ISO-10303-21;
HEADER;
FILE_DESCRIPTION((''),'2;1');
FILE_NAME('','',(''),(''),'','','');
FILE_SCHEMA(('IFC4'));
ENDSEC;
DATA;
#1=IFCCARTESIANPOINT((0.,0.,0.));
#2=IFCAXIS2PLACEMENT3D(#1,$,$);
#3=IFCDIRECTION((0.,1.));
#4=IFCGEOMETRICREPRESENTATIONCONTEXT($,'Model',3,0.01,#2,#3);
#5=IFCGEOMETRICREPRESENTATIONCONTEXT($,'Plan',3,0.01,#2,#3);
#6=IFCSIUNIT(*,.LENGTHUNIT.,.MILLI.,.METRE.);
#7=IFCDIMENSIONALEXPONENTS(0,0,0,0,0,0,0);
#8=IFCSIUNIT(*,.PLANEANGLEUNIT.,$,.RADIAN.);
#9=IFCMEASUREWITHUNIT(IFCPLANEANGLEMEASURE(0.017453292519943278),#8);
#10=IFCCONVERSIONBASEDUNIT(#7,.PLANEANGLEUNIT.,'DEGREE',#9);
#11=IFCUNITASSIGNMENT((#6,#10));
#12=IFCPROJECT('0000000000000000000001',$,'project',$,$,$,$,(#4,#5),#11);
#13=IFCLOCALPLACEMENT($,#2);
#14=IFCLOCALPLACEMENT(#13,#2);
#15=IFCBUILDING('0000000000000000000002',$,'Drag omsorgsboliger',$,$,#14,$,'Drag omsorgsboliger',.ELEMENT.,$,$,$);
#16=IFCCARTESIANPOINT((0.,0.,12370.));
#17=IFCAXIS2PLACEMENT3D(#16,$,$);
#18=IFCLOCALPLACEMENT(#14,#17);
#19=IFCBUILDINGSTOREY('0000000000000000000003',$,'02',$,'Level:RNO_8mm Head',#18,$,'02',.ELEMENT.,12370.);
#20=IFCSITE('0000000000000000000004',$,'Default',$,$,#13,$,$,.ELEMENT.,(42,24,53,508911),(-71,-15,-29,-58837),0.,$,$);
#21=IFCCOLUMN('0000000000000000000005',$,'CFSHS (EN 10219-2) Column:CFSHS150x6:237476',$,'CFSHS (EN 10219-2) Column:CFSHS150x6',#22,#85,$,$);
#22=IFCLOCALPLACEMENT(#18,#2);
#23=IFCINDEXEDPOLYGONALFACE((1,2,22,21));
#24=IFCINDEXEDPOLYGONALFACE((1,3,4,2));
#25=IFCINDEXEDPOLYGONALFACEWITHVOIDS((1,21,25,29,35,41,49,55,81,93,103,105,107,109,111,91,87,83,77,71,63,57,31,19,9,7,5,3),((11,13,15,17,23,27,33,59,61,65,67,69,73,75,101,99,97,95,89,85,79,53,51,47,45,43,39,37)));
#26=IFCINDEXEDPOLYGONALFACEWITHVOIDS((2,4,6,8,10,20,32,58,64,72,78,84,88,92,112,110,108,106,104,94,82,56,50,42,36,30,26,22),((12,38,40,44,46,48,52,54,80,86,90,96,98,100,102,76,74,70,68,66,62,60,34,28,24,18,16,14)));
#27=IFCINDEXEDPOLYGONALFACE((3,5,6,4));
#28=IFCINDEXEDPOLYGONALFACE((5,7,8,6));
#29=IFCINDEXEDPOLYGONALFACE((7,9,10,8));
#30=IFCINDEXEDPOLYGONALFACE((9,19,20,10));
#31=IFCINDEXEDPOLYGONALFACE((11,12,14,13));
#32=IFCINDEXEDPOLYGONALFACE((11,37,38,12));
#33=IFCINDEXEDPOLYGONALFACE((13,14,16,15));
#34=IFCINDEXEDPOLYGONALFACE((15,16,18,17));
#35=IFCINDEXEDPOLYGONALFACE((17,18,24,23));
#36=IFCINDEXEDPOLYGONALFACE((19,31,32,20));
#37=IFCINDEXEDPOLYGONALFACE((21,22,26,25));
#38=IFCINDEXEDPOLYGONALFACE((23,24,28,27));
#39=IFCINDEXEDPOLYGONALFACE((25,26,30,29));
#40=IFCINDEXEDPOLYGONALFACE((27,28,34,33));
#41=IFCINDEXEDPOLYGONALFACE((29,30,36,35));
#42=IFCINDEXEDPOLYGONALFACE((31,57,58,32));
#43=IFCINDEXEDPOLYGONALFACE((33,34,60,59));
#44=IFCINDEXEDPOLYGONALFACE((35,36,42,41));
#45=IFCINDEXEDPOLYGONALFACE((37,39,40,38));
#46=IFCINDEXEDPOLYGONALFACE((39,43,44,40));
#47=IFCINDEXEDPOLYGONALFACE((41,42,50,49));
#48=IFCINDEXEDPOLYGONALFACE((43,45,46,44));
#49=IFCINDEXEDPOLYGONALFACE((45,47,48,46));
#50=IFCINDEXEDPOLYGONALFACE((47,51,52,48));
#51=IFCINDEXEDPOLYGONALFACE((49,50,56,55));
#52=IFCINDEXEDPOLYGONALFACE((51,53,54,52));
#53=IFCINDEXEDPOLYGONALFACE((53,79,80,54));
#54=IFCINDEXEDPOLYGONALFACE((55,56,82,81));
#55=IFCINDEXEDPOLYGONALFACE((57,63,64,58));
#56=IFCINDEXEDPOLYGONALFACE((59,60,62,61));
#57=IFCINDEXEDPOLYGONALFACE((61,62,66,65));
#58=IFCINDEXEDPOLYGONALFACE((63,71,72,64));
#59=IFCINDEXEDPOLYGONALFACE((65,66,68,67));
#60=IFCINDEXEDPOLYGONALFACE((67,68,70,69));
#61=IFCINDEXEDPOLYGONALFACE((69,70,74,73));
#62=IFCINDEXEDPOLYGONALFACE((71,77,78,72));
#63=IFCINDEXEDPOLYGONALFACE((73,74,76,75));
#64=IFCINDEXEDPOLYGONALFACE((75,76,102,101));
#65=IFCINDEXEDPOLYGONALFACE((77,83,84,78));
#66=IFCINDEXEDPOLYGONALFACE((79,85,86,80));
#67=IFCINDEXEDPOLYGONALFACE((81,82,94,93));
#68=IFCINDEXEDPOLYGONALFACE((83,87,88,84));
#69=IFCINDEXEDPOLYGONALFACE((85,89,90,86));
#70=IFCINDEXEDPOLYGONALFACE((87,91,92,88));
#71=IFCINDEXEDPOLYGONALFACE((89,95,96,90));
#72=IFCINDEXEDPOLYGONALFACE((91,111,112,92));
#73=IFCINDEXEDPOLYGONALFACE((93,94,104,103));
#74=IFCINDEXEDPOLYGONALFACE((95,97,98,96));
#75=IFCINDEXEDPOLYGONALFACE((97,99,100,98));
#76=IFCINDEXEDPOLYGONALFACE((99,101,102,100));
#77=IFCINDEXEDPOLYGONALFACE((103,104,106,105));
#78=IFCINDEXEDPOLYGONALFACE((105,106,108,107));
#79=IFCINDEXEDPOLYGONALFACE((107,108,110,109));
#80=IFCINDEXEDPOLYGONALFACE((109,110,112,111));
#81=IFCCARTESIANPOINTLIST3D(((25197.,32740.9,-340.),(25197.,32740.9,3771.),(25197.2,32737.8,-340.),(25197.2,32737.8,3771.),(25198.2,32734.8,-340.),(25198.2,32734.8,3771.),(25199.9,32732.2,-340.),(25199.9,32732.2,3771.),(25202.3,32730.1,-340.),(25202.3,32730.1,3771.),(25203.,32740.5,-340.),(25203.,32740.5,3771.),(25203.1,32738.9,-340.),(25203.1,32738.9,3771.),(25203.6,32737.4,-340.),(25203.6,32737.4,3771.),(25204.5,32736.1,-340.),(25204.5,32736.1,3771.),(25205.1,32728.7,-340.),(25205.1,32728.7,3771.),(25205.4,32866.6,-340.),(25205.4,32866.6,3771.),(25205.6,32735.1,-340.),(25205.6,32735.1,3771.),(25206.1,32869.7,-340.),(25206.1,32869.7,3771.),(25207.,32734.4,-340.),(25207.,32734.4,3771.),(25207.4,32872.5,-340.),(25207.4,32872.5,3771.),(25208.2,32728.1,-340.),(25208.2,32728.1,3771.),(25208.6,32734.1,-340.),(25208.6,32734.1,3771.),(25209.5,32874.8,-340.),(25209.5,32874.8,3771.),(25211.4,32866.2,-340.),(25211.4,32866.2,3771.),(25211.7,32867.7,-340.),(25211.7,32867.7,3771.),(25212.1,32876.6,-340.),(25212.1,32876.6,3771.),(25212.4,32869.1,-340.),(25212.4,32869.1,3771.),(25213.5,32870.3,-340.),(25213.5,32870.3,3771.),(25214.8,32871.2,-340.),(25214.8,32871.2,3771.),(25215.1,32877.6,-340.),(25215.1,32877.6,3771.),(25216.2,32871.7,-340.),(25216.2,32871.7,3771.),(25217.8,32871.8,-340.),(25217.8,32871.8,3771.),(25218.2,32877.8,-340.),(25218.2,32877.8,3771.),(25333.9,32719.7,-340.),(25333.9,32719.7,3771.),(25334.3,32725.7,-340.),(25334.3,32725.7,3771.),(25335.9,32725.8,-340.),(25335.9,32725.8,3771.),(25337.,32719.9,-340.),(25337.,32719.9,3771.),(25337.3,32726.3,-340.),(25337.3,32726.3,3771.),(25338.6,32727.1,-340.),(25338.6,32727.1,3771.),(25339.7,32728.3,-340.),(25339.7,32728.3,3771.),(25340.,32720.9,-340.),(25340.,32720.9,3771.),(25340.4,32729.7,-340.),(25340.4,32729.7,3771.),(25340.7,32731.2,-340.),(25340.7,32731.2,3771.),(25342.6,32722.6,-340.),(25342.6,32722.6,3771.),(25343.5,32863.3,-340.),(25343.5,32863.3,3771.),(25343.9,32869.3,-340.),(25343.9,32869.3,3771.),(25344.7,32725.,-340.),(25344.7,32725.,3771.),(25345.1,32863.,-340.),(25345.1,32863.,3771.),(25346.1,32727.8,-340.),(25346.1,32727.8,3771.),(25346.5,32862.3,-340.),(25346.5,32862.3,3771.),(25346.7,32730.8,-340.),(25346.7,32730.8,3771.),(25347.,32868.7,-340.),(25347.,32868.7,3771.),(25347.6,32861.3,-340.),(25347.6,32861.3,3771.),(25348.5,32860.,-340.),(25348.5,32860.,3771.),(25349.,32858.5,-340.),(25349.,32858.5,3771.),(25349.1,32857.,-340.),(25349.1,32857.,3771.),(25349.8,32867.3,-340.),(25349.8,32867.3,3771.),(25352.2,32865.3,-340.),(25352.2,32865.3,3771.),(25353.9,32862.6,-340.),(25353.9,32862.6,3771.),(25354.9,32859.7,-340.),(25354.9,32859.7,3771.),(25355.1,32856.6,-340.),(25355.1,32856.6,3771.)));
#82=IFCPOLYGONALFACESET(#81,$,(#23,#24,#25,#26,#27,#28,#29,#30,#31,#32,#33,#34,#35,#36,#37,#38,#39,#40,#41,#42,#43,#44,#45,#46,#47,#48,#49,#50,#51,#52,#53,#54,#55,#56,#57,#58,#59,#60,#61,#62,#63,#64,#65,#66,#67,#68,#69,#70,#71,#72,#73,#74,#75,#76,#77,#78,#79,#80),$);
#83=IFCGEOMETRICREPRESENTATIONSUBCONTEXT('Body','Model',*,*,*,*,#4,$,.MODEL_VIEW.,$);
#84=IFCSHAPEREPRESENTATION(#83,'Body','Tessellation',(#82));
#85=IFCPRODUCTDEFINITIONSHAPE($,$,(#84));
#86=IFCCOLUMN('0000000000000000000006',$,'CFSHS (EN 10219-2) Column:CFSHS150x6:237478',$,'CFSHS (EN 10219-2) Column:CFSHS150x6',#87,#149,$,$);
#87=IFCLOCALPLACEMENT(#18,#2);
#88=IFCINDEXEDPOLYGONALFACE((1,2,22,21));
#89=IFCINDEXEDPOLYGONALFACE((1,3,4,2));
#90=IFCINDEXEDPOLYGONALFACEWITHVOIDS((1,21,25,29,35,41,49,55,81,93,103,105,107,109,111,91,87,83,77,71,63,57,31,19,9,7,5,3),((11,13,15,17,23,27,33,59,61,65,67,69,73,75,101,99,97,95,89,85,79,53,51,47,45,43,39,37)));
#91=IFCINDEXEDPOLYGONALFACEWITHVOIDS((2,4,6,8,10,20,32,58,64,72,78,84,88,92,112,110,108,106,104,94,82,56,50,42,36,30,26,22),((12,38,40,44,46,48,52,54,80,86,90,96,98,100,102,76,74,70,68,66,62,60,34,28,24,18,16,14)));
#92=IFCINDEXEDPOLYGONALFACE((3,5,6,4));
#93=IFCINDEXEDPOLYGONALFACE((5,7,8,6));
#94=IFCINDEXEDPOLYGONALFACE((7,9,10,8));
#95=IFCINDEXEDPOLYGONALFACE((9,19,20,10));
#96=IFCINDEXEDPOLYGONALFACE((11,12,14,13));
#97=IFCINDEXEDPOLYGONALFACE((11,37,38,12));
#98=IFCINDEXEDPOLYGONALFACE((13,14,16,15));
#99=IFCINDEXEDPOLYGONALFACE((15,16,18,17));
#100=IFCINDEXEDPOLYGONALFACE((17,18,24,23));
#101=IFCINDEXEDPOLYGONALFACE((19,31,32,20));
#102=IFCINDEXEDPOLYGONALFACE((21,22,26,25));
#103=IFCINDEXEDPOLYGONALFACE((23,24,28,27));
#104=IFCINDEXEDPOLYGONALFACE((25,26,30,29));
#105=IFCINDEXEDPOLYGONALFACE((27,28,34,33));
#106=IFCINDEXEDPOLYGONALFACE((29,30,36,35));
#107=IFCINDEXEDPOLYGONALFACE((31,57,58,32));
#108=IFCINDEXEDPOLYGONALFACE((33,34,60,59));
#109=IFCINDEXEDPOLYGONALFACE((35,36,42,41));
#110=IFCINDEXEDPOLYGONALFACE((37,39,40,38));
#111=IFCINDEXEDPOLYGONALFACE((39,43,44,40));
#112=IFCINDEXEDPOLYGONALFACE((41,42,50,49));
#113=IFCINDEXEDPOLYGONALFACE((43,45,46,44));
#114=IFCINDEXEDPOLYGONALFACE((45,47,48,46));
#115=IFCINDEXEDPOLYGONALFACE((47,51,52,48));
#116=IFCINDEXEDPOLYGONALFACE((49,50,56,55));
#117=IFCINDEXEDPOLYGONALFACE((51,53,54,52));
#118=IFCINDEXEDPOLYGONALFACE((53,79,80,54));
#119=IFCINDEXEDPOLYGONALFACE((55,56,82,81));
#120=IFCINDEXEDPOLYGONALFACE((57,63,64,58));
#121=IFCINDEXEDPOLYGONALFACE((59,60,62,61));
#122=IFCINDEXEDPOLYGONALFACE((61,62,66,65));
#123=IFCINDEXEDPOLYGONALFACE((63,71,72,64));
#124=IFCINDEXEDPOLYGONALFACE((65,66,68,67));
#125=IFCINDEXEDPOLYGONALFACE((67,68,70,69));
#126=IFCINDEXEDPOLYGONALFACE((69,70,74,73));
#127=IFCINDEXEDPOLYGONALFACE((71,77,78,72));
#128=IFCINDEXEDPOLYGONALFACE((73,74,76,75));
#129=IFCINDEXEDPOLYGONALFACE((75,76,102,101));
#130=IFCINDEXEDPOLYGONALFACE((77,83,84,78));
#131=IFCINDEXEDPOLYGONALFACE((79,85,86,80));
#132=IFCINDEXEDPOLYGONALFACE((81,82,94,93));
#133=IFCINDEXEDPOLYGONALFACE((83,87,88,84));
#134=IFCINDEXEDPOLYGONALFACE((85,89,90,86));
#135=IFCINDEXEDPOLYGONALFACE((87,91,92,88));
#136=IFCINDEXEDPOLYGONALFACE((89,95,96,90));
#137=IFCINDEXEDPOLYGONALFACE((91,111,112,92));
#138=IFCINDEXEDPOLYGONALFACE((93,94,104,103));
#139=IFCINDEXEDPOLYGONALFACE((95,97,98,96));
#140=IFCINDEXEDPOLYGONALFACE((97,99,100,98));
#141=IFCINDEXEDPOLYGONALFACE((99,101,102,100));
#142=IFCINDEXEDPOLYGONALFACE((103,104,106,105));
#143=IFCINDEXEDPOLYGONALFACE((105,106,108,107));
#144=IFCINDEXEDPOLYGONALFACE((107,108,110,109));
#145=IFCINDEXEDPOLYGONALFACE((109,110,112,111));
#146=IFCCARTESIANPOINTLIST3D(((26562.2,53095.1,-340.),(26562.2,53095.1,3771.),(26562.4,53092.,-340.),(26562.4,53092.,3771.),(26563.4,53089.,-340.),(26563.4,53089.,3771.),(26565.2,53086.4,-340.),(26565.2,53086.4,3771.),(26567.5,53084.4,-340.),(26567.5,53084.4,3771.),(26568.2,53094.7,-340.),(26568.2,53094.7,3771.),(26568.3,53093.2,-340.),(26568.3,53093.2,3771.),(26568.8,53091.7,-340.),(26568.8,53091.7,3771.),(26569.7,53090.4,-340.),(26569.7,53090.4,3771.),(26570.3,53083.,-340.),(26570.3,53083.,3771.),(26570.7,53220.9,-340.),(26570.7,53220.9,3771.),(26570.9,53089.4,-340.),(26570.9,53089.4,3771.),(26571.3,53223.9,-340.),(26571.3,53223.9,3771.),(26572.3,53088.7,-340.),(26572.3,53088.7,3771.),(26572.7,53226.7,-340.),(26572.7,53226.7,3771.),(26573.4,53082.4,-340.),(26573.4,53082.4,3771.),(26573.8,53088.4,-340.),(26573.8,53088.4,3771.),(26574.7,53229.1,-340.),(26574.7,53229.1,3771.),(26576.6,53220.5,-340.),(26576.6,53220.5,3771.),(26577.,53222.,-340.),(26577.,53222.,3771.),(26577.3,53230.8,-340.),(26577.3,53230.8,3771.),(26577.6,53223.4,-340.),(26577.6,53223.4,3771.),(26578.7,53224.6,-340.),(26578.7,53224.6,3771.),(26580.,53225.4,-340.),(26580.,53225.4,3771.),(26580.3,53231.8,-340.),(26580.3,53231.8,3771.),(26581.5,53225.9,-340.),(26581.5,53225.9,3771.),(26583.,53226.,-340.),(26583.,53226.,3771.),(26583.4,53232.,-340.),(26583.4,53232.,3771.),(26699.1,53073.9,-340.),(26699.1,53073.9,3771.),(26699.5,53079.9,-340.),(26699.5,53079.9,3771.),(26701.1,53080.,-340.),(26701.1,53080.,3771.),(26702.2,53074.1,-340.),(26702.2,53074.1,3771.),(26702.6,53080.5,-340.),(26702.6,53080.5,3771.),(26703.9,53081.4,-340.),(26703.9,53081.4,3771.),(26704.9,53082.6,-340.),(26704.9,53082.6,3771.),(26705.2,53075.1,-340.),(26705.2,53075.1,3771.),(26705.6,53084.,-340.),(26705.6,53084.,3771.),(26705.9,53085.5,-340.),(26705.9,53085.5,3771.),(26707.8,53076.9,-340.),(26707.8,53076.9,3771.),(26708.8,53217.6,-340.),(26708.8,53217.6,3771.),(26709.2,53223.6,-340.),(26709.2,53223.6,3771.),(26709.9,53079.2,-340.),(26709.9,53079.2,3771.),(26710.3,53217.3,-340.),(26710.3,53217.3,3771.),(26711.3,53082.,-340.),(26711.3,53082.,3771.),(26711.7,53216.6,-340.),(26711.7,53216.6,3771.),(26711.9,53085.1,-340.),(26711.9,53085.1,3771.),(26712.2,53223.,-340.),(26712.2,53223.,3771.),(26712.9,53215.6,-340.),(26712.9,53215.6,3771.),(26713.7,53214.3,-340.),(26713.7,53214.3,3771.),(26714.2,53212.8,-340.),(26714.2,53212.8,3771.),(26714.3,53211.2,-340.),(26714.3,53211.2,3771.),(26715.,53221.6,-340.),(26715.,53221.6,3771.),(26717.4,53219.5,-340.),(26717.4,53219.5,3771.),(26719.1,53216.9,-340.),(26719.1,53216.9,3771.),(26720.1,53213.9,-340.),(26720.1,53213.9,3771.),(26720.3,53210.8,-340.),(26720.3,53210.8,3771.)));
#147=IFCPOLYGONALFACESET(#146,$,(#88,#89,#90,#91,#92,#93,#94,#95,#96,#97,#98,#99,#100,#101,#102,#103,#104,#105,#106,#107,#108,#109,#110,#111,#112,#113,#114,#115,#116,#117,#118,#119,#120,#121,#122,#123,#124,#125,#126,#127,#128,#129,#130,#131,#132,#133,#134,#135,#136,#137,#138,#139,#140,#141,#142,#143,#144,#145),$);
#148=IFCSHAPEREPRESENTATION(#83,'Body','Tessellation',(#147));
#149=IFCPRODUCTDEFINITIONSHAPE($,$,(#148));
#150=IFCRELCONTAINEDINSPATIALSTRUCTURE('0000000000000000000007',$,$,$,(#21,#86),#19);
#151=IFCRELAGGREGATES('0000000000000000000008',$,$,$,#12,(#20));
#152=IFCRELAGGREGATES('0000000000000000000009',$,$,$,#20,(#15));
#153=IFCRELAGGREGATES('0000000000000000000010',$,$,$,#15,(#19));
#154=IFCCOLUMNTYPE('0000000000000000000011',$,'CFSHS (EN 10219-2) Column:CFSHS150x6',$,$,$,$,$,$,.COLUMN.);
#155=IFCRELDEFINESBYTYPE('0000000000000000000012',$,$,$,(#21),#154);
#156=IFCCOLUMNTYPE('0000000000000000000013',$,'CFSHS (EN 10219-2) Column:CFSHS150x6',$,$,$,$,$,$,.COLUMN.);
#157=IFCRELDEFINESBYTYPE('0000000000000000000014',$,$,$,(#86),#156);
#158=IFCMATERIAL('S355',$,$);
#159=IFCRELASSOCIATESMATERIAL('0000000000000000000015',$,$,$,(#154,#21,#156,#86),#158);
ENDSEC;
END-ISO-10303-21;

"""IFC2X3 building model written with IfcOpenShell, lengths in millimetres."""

from ifc_helpers import new_model, entity, si_unit, converted_unit, direction, frame, frame_2d, origin, place, context, subcontext, project, spatial, polyline, circle_curve, parameter, trimmed, segment, composite_curve, outline, extrude, source, transform, mapped, material, type_object, type_shapes, element, save


model = new_model("IFC2X3")

# Units and contexts
model_context = context("Model", 3, precision=0.01, world=origin(), true_north=direction((0.0, 1.0)))
plan_context = context("Plan", 3, precision=0.01, world=origin(), true_north=direction((0.0, 1.0)))
body_context = subcontext(model_context, "Body", "Model", "MODEL_VIEW")
ifc_project = project(units=[si_unit("LENGTHUNIT", "METRE", prefix="MILLI"), converted_unit("PLANEANGLEUNIT", "DEGREE", entity("IfcPlaneAngleMeasure", 0.017453292519943278), si_unit("PLANEANGLEUNIT", "RADIAN"), dimensions=[0, 0, 0, 0, 0, 0, 0])], contexts=[model_context, plan_context])

# Site, building, storey
site_placement = place(None, origin())
site = spatial("IfcSite", under=ifc_project, at=site_placement, Name="Default", CompositionType="ELEMENT", RefLatitude=(42, 24, 53, 508911), RefLongitude=(-71, -15, -29, -58837), RefElevation=0.0)
building_placement = place(site_placement, origin())
building = spatial("IfcBuilding", under=site, at=building_placement, Name="Drag omsorgsboliger", LongName="Drag omsorgsboliger", CompositionType="ELEMENT")
storey_placement = place(building_placement, frame((0.0, 0.0, 12370.0)))
storey = spatial("IfcBuildingStorey", under=building, at=storey_placement, Name="02", ObjectType="Level:RNO_8mm Head", LongName="02", CompositionType="ELEMENT", Elevation=12370.0)

# Columns
ifc_material = material(Name="S355")
column_type_1 = type_object("IfcColumnType", Name="CFSHS (EN 10219-2) Column:CFSHS150x6", PredefinedType="COLUMN", material=ifc_material)
shared_shape_1 = source(origin(), body_context, "Body", "SweptSolid", [
    extrude(outline(composite_curve([segment(polyline([(-63.0, -75.0), (63.0, -75.0)]), True, "CONTINUOUS"), segment(trimmed(circle_curve(frame_2d((63.0, -63.0), x_axis=(-1.0, 0.0)), 12.0), [parameter(90.0)], [parameter(180.0)], True, "PARAMETER"), True, "CONTINUOUS"), segment(polyline([(75.0, -63.0), (75.0, 63.0)]), True, "CONTINUOUS"), segment(trimmed(circle_curve(frame_2d((63.0, 63.0), x_axis=(-1.0, 0.0)), 12.0), [parameter(180.0)], [parameter(270.0)], True, "PARAMETER"), True, "CONTINUOUS"), segment(polyline([(63.0, 75.0), (-63.0, 75.0)]), True, "CONTINUOUS"), segment(trimmed(circle_curve(frame_2d((-63.0, 63.0), x_axis=(-1.0, 0.0)), 12.0), [parameter(270.0)], [parameter(360.0)], True, "PARAMETER"), True, "CONTINUOUS"), segment(polyline([(-75.0, 63.0), (-75.0, -63.0)]), True, "CONTINUOUS"), segment(trimmed(circle_curve(frame_2d((-63.0, -63.0), x_axis=(-1.0, 0.0)), 12.0), [parameter(360.0)], [parameter(90.0)], True, "PARAMETER"), True, "CONTINUOUS")], self_intersect=False), holes=[composite_curve([segment(trimmed(circle_curve(frame_2d((-63.0, -63.0), x_axis=(-1.0, 0.0)), 6.0), [parameter(360.0)], [parameter(90.0)], True, "PARAMETER"), False, "CONTINUOUS"), segment(polyline([(-69.0, -63.0), (-69.0, 63.0)]), True, "CONTINUOUS"), segment(trimmed(circle_curve(frame_2d((-63.0, 63.0), x_axis=(-1.0, 0.0)), 6.0), [parameter(270.0)], [parameter(360.0)], True, "PARAMETER"), False, "CONTINUOUS"), segment(polyline([(-63.0, 69.0), (63.0, 69.0)]), True, "CONTINUOUS"), segment(trimmed(circle_curve(frame_2d((63.0, 63.0), x_axis=(-1.0, 0.0)), 6.0), [parameter(180.0)], [parameter(270.0)], True, "PARAMETER"), False, "CONTINUOUS"), segment(polyline([(69.0, 63.0), (69.0, -63.0)]), True, "CONTINUOUS"), segment(trimmed(circle_curve(frame_2d((63.0, -63.0), x_axis=(-1.0, 0.0)), 6.0), [parameter(90.0)], [parameter(180.0)], True, "PARAMETER"), False, "CONTINUOUS"), segment(polyline([(63.0, -69.0), (-63.0, -69.0)]), True, "CONTINUOUS")], self_intersect=False)]), frame((25276.1, 32798.7, 12030.0), z_axis=(0.0, 0.0, 1.0), x_axis=(-0.997758, 0.066923, 0.0)), (0.0, 0.0, 1.0), 4111.0),
])
type_shapes(column_type_1, [shared_shape_1])
column_1_placement = place(storey_placement, frame((0.0, 0.0, -12370.0)))
element("IfcColumn", 1, at=column_1_placement, inside=storey, type_object=column_type_1, material=ifc_material, Name="CFSHS (EN 10219-2) Column:CFSHS150x6:237476", ObjectType="CFSHS (EN 10219-2) Column:CFSHS150x6", context=body_context, shape_type="MappedRepresentation", body=[
    mapped(shared_shape_1, transform((0.0, 0.0, 0.0), scale=1.0)),
])
column_type_2 = type_object("IfcColumnType", Name="CFSHS (EN 10219-2) Column:CFSHS150x6", PredefinedType="COLUMN", material=ifc_material)
shared_shape_2 = source(origin(), body_context, "Body", "SweptSolid", [
    extrude(outline(composite_curve([segment(polyline([(-63.0, -75.0), (63.0, -75.0)]), True, "CONTINUOUS"), segment(trimmed(circle_curve(frame_2d((63.0, -63.0), x_axis=(-1.0, 0.0)), 12.0), [parameter(90.0)], [parameter(180.0)], True, "PARAMETER"), True, "CONTINUOUS"), segment(polyline([(75.0, -63.0), (75.0, 63.0)]), True, "CONTINUOUS"), segment(trimmed(circle_curve(frame_2d((63.0, 63.0), x_axis=(-1.0, 0.0)), 12.0), [parameter(180.0)], [parameter(270.0)], True, "PARAMETER"), True, "CONTINUOUS"), segment(polyline([(63.0, 75.0), (-63.0, 75.0)]), True, "CONTINUOUS"), segment(trimmed(circle_curve(frame_2d((-63.0, 63.0), x_axis=(-1.0, 0.0)), 12.0), [parameter(270.0)], [parameter(360.0)], True, "PARAMETER"), True, "CONTINUOUS"), segment(polyline([(-75.0, 63.0), (-75.0, -63.0)]), True, "CONTINUOUS"), segment(trimmed(circle_curve(frame_2d((-63.0, -63.0), x_axis=(-1.0, 0.0)), 12.0), [parameter(360.0)], [parameter(90.0)], True, "PARAMETER"), True, "CONTINUOUS")], self_intersect=False), holes=[composite_curve([segment(trimmed(circle_curve(frame_2d((-63.0, -63.0), x_axis=(-1.0, 0.0)), 6.0), [parameter(360.0)], [parameter(90.0)], True, "PARAMETER"), False, "CONTINUOUS"), segment(polyline([(-69.0, -63.0), (-69.0, 63.0)]), True, "CONTINUOUS"), segment(trimmed(circle_curve(frame_2d((-63.0, 63.0), x_axis=(-1.0, 0.0)), 6.0), [parameter(270.0)], [parameter(360.0)], True, "PARAMETER"), False, "CONTINUOUS"), segment(polyline([(-63.0, 69.0), (63.0, 69.0)]), True, "CONTINUOUS"), segment(trimmed(circle_curve(frame_2d((63.0, 63.0), x_axis=(-1.0, 0.0)), 6.0), [parameter(180.0)], [parameter(270.0)], True, "PARAMETER"), False, "CONTINUOUS"), segment(polyline([(69.0, 63.0), (69.0, -63.0)]), True, "CONTINUOUS"), segment(trimmed(circle_curve(frame_2d((63.0, -63.0), x_axis=(-1.0, 0.0)), 6.0), [parameter(90.0)], [parameter(180.0)], True, "PARAMETER"), False, "CONTINUOUS"), segment(polyline([(63.0, -69.0), (-63.0, -69.0)]), True, "CONTINUOUS")], self_intersect=False)]), frame((26641.3, 53153.0, 12030.0), z_axis=(0.0, 0.0, 1.0), x_axis=(-0.997758, 0.066923, 0.0)), (0.0, 0.0, 1.0), 4111.0),
])
type_shapes(column_type_2, [shared_shape_2])
column_2_placement = place(storey_placement, frame((0.0, 0.0, -12370.0)))
element("IfcColumn", 2, at=column_2_placement, inside=storey, type_object=column_type_2, material=ifc_material, Name="CFSHS (EN 10219-2) Column:CFSHS150x6:237478", ObjectType="CFSHS (EN 10219-2) Column:CFSHS150x6", context=body_context, shape_type="MappedRepresentation", body=[
    mapped(shared_shape_2, transform((0.0, 0.0, 0.0), scale=1.0)),
])

save(model, "model.ifc")
